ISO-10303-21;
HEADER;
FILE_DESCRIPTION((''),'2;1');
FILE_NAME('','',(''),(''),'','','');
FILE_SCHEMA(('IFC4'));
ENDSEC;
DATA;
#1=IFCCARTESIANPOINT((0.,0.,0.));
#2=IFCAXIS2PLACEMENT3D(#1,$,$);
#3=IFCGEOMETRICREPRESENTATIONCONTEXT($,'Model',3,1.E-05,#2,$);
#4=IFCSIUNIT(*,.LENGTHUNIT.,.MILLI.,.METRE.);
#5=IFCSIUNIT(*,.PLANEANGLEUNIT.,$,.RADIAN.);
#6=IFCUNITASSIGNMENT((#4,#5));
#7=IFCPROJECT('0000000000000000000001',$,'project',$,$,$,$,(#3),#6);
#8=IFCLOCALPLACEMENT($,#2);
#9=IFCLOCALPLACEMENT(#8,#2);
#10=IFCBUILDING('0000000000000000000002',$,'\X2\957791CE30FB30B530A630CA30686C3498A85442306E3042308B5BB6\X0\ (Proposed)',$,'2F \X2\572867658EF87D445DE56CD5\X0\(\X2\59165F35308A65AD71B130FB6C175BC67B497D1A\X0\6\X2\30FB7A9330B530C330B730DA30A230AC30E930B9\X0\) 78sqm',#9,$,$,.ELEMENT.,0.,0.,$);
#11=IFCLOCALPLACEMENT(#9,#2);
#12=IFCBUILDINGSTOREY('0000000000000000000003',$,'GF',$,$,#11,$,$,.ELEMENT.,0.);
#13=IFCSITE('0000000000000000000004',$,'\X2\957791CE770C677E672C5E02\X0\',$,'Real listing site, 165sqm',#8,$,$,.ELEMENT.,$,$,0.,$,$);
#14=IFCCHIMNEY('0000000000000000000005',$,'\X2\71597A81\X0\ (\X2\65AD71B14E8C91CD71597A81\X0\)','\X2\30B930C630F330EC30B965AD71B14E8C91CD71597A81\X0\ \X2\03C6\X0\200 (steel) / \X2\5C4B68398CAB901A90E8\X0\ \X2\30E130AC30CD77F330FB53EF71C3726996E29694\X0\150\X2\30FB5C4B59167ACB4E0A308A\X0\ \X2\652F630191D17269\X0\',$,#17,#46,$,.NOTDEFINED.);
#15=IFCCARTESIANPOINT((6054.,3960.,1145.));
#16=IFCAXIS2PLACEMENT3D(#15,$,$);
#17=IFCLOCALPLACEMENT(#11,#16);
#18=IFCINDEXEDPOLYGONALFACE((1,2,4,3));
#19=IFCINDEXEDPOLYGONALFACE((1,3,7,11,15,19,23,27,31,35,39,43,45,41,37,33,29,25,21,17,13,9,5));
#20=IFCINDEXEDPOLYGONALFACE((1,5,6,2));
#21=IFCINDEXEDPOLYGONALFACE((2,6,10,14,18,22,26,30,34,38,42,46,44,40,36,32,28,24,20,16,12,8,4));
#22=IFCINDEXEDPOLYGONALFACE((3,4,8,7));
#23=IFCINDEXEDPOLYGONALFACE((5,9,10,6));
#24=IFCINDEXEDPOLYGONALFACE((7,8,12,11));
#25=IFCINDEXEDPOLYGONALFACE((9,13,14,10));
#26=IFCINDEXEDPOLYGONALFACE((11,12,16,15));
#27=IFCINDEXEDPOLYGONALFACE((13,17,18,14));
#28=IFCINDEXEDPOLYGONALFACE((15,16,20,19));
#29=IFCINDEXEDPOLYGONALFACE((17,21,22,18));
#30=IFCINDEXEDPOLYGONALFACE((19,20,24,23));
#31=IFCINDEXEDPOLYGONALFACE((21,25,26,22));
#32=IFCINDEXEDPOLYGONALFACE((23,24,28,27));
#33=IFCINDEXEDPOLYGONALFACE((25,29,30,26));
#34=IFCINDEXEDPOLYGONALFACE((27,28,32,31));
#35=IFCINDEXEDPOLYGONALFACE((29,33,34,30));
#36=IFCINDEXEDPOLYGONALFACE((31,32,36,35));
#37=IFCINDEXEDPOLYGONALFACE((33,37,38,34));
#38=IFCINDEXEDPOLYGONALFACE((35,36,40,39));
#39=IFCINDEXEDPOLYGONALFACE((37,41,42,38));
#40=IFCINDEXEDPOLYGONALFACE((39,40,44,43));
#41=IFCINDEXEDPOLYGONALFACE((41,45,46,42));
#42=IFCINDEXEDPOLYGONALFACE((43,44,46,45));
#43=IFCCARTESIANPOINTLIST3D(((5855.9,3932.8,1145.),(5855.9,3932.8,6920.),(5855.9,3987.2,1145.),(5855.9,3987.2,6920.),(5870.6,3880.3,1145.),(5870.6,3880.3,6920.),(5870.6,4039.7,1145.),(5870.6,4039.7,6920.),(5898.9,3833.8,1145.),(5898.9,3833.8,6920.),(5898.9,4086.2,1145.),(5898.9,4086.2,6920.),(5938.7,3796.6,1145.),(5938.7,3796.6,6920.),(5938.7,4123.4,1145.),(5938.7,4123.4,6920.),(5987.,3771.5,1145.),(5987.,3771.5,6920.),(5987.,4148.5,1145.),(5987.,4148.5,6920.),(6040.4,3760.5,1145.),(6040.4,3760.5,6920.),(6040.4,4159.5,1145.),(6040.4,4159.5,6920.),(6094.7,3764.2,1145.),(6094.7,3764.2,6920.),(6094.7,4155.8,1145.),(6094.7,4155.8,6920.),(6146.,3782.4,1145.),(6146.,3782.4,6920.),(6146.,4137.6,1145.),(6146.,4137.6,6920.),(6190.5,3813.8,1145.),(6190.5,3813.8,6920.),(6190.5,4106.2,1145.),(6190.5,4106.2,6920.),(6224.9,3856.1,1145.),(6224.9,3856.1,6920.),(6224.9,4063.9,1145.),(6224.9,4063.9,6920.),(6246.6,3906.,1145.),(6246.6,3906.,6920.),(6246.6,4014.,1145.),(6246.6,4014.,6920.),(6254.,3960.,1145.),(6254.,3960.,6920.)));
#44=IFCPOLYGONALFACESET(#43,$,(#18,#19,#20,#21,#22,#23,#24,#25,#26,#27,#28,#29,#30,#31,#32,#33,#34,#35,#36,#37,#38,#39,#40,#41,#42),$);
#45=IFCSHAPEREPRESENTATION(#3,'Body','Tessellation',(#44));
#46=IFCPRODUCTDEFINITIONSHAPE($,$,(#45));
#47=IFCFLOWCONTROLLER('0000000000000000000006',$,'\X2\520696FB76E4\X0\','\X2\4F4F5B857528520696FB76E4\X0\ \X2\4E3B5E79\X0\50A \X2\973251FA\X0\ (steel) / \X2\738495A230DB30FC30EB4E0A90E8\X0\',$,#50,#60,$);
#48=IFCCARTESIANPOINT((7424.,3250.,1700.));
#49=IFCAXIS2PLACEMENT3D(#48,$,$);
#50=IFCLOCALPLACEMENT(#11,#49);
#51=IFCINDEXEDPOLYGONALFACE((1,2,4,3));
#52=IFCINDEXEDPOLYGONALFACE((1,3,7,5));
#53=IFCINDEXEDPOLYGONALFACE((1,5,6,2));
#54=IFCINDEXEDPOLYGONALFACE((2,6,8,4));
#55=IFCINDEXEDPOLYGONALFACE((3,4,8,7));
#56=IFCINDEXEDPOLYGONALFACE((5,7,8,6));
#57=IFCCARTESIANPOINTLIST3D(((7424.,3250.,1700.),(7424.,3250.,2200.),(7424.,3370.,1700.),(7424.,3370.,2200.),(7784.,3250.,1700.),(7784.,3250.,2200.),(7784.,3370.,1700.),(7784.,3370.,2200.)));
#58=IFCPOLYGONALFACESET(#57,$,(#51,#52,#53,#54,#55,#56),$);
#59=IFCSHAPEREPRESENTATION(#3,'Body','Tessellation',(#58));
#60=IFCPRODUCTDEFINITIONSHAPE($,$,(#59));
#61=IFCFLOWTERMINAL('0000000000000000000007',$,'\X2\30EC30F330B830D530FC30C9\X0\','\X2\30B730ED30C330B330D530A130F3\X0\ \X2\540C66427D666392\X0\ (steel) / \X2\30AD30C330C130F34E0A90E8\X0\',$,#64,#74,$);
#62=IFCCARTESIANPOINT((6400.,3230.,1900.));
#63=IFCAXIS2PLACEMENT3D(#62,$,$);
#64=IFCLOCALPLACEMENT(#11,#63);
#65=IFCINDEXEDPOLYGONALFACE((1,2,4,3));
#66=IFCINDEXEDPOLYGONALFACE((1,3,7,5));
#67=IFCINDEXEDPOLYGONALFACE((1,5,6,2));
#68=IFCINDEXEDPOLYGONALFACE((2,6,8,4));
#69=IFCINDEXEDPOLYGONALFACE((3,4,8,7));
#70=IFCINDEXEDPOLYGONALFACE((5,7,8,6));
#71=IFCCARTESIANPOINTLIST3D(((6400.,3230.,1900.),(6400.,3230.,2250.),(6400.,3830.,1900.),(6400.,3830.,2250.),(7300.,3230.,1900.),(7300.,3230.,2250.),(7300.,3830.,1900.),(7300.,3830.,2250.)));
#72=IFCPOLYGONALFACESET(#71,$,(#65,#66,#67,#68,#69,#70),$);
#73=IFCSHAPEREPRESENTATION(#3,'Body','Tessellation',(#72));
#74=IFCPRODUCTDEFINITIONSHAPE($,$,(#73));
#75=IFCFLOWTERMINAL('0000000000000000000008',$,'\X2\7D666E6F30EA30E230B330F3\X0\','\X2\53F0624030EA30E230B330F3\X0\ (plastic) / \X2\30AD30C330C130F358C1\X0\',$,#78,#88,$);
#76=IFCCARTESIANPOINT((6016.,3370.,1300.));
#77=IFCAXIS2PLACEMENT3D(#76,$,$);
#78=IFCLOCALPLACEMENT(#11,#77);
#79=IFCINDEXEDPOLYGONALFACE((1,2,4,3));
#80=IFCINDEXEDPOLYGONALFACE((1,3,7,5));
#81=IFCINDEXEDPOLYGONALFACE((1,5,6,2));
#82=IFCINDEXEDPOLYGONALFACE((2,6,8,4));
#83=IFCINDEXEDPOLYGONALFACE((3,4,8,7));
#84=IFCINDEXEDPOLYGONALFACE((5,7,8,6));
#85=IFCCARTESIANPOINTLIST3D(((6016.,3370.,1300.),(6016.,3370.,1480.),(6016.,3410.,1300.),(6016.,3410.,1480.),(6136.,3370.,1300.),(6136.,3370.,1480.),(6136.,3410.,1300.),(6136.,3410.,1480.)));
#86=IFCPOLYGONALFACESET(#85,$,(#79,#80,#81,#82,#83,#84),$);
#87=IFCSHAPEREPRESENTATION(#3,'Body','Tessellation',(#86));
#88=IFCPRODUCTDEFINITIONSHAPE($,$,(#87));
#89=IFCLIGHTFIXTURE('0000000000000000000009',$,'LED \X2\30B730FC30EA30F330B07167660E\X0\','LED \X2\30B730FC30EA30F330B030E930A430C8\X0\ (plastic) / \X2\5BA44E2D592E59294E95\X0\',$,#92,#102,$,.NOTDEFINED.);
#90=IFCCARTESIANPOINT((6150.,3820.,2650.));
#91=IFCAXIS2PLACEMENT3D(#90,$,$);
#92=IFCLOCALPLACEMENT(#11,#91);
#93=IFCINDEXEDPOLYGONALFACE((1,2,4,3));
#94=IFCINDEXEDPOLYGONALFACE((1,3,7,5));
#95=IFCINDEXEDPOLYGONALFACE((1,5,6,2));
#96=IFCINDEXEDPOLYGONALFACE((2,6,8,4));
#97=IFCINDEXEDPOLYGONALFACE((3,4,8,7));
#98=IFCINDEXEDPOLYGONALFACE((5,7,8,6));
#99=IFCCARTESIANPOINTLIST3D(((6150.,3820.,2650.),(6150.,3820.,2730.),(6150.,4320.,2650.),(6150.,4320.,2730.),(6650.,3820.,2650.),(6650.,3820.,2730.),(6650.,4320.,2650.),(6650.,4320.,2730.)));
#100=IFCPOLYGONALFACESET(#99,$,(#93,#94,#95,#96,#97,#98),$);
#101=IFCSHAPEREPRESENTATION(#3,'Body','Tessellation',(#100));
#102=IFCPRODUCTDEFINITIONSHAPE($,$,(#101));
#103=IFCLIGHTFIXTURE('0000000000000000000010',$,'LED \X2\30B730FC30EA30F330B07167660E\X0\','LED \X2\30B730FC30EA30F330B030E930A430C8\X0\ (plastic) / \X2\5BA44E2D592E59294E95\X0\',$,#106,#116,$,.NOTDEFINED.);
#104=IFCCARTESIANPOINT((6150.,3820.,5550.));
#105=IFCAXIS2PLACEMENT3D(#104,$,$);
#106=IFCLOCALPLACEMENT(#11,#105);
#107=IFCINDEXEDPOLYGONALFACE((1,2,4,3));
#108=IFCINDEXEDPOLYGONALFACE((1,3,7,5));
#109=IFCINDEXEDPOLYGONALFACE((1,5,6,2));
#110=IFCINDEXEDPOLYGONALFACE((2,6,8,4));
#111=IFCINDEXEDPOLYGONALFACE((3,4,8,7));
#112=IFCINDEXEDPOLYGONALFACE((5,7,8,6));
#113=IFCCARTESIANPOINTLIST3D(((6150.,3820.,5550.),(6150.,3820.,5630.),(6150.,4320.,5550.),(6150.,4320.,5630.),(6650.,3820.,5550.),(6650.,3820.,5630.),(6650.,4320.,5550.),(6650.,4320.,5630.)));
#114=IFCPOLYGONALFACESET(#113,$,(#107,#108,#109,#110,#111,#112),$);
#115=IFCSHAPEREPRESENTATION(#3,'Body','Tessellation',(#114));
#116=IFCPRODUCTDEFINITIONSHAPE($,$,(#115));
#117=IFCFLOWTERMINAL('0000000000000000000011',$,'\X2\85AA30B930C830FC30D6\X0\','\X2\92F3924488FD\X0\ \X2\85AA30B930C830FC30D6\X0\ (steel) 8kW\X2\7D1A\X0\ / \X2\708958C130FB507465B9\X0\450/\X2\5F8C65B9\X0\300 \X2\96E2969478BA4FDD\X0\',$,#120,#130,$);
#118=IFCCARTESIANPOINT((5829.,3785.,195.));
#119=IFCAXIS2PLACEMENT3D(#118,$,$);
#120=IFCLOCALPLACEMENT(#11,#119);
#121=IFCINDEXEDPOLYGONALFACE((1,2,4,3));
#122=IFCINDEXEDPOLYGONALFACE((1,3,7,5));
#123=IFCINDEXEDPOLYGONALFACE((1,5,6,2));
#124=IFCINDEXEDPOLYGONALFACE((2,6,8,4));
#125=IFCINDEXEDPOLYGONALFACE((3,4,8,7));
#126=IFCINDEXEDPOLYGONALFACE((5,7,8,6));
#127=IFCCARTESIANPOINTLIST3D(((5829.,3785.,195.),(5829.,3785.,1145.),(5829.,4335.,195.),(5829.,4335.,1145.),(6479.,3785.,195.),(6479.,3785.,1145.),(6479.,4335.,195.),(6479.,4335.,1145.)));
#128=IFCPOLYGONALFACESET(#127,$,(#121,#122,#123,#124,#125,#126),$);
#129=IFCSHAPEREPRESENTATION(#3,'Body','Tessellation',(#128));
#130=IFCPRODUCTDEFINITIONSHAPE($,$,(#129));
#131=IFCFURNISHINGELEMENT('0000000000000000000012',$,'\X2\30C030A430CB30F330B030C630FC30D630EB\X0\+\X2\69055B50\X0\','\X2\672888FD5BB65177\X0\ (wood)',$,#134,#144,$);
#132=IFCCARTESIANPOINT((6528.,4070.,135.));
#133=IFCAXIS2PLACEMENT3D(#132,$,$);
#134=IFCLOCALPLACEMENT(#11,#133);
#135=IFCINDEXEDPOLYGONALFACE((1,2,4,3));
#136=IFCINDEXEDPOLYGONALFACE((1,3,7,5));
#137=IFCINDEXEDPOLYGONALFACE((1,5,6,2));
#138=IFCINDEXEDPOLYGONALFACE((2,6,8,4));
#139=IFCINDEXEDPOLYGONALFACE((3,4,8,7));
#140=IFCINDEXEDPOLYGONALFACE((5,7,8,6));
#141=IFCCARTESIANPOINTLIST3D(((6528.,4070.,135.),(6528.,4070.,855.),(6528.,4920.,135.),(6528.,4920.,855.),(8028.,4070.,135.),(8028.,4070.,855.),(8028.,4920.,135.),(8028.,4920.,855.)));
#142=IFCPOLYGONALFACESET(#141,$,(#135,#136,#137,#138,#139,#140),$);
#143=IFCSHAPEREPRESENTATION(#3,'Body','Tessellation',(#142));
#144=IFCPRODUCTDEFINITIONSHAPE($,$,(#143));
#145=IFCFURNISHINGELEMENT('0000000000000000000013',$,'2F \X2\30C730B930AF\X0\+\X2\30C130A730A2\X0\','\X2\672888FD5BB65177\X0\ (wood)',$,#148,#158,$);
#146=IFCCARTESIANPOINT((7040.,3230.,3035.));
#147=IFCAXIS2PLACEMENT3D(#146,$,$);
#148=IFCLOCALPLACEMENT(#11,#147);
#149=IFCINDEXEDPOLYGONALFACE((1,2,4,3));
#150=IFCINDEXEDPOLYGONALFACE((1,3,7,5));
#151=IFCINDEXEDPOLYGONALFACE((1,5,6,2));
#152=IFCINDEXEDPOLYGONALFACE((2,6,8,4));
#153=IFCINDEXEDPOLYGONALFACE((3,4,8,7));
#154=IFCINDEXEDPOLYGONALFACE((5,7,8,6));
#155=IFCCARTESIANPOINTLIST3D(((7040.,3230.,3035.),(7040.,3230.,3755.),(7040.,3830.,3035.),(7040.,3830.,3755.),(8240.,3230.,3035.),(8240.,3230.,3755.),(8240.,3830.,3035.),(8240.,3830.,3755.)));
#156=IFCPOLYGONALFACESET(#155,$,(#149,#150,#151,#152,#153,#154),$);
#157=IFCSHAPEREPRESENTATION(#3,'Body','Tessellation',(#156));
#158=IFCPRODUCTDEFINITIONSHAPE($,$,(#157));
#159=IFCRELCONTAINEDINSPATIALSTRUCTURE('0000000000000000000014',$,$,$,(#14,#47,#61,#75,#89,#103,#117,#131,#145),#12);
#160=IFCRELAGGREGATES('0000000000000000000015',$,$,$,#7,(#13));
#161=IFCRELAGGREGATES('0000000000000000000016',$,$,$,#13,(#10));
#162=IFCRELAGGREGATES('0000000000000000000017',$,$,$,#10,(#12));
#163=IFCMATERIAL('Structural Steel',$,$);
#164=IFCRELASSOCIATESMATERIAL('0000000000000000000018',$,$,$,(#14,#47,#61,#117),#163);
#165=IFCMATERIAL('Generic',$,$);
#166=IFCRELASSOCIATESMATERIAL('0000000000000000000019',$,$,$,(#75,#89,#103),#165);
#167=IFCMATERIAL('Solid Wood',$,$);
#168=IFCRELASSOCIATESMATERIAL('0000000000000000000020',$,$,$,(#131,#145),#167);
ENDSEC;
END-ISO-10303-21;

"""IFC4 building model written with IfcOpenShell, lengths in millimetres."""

from ifc_helpers import new_model, si_unit, frame, frame_2d, origin, origin_2d, place, context, project, spatial, rectangle, circle, extrude, material, element, save


model = new_model("IFC4")

# Units and contexts
model_context = context("Model", 3, precision=1e-05, world=origin())
ifc_project = project(units=[si_unit("LENGTHUNIT", "METRE", prefix="MILLI"), si_unit("PLANEANGLEUNIT", "RADIAN")], contexts=[model_context])

# Site, building, storey
site_placement = place(None, origin())
site = spatial("IfcSite", under=ifc_project, at=site_placement, Name="長野県松本市", ObjectType="Real listing site, 165sqm", CompositionType="ELEMENT", RefElevation=0.0)
building_placement = place(site_placement, origin())
building = spatial("IfcBuilding", under=site, at=building_placement, Name="長野・サウナと水風呂のある家 (Proposed)", ObjectType="2F 在来軸組工法(外張り断熱・気密等級6・窓サッシペアガラス) 78sqm", CompositionType="ELEMENT", ElevationOfRefHeight=0.0, ElevationOfTerrain=0.0)
storey_placement = place(building_placement, origin())
storey = spatial("IfcBuildingStorey", under=building, at=storey_placement, Name="GF", CompositionType="ELEMENT", Elevation=0.0)

# Shared definitions
ifc_material_1 = material(Name="Solid Wood")

# Shared definitions
ifc_material_2 = material(Name="Structural Steel")

# Chimney
chimney_placement = place(storey_placement, frame((6054.0, 3960.0, 1145.0)))
element("IfcChimney", 1, at=chimney_placement, inside=storey, material=ifc_material_2, Name="煙突 (断熱二重煙突)", Description="ステンレス断熱二重煙突 φ200 (steel) / 屋根貫通部 メガネ石・可燃物離隔150・屋外立上り 支持金物", PredefinedType="NOTDEFINED", context=model_context, shape_type="SweptSolid", body=[
    extrude(circle(Radius=200.0, at=origin_2d()), frame((6054.0, 3960.0, 1145.0)), (0.0, 0.0, 1.0), 5775.0),
])

# Flow controller
flow_controller_placement = place(storey_placement, frame((7424.0, 3250.0, 1700.0)))
element("IfcFlowController", 2, at=flow_controller_placement, inside=storey, material=ifc_material_2, Name="分電盤", Description="住宅用分電盤 主幹50A 露出 (steel) / 玄関ホール上部", context=model_context, shape_type="SweptSolid", body=[
    extrude(rectangle(XDim=360.0, YDim=120.0, at=frame_2d((180.0, 60.0))), frame((7424.0, 3250.0, 1700.0)), (0.0, 0.0, 1.0), 500.0),
])

# Flow terminals
flow_terminal_1_placement = place(storey_placement, frame((6400.0, 3230.0, 1900.0)))
element("IfcFlowTerminal", 3, at=flow_terminal_1_placement, inside=storey, material=ifc_material_2, Name="レンジフード", Description="シロッコファン 同時給排 (steel) / キッチン上部", context=model_context, shape_type="SweptSolid", body=[
    extrude(rectangle(XDim=900.0, YDim=600.0, at=frame_2d((450.0, 300.0))), frame((6400.0, 3230.0, 1900.0)), (0.0, 0.0, 1.0), 350.0),
])
ifc_material_3 = material(Name="Generic")
flow_terminal_2_placement = place(storey_placement, frame((6016.0, 3370.0, 1300.0)))
element("IfcFlowTerminal", 4, at=flow_terminal_2_placement, inside=storey, material=ifc_material_3, Name="給湯リモコン", Description="台所リモコン (plastic) / キッチン壁", context=model_context, shape_type="SweptSolid", body=[
    extrude(rectangle(XDim=120.0, YDim=40.0, at=frame_2d((60.0, 20.0))), frame((6016.0, 3370.0, 1300.0)), (0.0, 0.0, 1.0), 180.0),
])

# Light fixtures
light_fixture_1_placement = place(storey_placement, frame((6150.0, 3820.0, 2650.0)))
element("IfcLightFixture", 5, at=light_fixture_1_placement, inside=storey, material=ifc_material_3, Name="LED シーリング照明", Description="LED シーリングライト (plastic) / 室中央天井", PredefinedType="NOTDEFINED", context=model_context, shape_type="SweptSolid", body=[
    extrude(rectangle(XDim=500.0, YDim=500.0, at=frame_2d((250.0, 250.0))), frame((6150.0, 3820.0, 2650.0)), (0.0, 0.0, 1.0), 80.0),
])
light_fixture_2_placement = place(storey_placement, frame((6150.0, 3820.0, 5550.0)))
element("IfcLightFixture", 6, at=light_fixture_2_placement, inside=storey, material=ifc_material_3, Name="LED シーリング照明", Description="LED シーリングライト (plastic) / 室中央天井", PredefinedType="NOTDEFINED", context=model_context, shape_type="SweptSolid", body=[
    extrude(rectangle(XDim=500.0, YDim=500.0, at=frame_2d((250.0, 250.0))), frame((6150.0, 3820.0, 5550.0)), (0.0, 0.0, 1.0), 80.0),
])

# Flow terminal
flow_terminal_3_placement = place(storey_placement, frame((5829.0, 3785.0, 195.0)))
element("IfcFlowTerminal", 7, at=flow_terminal_3_placement, inside=storey, material=ifc_material_2, Name="薪ストーブ", Description="鋳鉄製 薪ストーブ (steel) 8kW級 / 炉壁・側方450/後方300 離隔確保", context=model_context, shape_type="SweptSolid", body=[
    extrude(rectangle(XDim=650.0, YDim=550.0, at=frame_2d((325.0, 275.0))), frame((5829.0, 3785.0, 195.0)), (0.0, 0.0, 1.0), 950.0),
])

# Furnishing elements
furnishing_1_placement = place(storey_placement, frame((6528.0, 4070.0, 135.0)))
element("IfcFurnishingElement", 8, at=furnishing_1_placement, inside=storey, material=ifc_material_1, Name="ダイニングテーブル+椅子", Description="木製家具 (wood)", context=model_context, shape_type="SweptSolid", body=[
    extrude(rectangle(XDim=1500.0, YDim=850.0, at=frame_2d((750.0, 425.0))), frame((6528.0, 4070.0, 135.0)), (0.0, 0.0, 1.0), 720.0),
])
furnishing_2_placement = place(storey_placement, frame((7040.0, 3230.0, 3035.0)))
element("IfcFurnishingElement", 9, at=furnishing_2_placement, inside=storey, material=ifc_material_1, Name="2F デスク+チェア", Description="木製家具 (wood)", context=model_context, shape_type="SweptSolid", body=[
    extrude(rectangle(XDim=1200.0, YDim=600.0, at=frame_2d((600.0, 300.0))), frame((7040.0, 3230.0, 3035.0)), (0.0, 0.0, 1.0), 720.0),
])

save(model, "model.ifc")
